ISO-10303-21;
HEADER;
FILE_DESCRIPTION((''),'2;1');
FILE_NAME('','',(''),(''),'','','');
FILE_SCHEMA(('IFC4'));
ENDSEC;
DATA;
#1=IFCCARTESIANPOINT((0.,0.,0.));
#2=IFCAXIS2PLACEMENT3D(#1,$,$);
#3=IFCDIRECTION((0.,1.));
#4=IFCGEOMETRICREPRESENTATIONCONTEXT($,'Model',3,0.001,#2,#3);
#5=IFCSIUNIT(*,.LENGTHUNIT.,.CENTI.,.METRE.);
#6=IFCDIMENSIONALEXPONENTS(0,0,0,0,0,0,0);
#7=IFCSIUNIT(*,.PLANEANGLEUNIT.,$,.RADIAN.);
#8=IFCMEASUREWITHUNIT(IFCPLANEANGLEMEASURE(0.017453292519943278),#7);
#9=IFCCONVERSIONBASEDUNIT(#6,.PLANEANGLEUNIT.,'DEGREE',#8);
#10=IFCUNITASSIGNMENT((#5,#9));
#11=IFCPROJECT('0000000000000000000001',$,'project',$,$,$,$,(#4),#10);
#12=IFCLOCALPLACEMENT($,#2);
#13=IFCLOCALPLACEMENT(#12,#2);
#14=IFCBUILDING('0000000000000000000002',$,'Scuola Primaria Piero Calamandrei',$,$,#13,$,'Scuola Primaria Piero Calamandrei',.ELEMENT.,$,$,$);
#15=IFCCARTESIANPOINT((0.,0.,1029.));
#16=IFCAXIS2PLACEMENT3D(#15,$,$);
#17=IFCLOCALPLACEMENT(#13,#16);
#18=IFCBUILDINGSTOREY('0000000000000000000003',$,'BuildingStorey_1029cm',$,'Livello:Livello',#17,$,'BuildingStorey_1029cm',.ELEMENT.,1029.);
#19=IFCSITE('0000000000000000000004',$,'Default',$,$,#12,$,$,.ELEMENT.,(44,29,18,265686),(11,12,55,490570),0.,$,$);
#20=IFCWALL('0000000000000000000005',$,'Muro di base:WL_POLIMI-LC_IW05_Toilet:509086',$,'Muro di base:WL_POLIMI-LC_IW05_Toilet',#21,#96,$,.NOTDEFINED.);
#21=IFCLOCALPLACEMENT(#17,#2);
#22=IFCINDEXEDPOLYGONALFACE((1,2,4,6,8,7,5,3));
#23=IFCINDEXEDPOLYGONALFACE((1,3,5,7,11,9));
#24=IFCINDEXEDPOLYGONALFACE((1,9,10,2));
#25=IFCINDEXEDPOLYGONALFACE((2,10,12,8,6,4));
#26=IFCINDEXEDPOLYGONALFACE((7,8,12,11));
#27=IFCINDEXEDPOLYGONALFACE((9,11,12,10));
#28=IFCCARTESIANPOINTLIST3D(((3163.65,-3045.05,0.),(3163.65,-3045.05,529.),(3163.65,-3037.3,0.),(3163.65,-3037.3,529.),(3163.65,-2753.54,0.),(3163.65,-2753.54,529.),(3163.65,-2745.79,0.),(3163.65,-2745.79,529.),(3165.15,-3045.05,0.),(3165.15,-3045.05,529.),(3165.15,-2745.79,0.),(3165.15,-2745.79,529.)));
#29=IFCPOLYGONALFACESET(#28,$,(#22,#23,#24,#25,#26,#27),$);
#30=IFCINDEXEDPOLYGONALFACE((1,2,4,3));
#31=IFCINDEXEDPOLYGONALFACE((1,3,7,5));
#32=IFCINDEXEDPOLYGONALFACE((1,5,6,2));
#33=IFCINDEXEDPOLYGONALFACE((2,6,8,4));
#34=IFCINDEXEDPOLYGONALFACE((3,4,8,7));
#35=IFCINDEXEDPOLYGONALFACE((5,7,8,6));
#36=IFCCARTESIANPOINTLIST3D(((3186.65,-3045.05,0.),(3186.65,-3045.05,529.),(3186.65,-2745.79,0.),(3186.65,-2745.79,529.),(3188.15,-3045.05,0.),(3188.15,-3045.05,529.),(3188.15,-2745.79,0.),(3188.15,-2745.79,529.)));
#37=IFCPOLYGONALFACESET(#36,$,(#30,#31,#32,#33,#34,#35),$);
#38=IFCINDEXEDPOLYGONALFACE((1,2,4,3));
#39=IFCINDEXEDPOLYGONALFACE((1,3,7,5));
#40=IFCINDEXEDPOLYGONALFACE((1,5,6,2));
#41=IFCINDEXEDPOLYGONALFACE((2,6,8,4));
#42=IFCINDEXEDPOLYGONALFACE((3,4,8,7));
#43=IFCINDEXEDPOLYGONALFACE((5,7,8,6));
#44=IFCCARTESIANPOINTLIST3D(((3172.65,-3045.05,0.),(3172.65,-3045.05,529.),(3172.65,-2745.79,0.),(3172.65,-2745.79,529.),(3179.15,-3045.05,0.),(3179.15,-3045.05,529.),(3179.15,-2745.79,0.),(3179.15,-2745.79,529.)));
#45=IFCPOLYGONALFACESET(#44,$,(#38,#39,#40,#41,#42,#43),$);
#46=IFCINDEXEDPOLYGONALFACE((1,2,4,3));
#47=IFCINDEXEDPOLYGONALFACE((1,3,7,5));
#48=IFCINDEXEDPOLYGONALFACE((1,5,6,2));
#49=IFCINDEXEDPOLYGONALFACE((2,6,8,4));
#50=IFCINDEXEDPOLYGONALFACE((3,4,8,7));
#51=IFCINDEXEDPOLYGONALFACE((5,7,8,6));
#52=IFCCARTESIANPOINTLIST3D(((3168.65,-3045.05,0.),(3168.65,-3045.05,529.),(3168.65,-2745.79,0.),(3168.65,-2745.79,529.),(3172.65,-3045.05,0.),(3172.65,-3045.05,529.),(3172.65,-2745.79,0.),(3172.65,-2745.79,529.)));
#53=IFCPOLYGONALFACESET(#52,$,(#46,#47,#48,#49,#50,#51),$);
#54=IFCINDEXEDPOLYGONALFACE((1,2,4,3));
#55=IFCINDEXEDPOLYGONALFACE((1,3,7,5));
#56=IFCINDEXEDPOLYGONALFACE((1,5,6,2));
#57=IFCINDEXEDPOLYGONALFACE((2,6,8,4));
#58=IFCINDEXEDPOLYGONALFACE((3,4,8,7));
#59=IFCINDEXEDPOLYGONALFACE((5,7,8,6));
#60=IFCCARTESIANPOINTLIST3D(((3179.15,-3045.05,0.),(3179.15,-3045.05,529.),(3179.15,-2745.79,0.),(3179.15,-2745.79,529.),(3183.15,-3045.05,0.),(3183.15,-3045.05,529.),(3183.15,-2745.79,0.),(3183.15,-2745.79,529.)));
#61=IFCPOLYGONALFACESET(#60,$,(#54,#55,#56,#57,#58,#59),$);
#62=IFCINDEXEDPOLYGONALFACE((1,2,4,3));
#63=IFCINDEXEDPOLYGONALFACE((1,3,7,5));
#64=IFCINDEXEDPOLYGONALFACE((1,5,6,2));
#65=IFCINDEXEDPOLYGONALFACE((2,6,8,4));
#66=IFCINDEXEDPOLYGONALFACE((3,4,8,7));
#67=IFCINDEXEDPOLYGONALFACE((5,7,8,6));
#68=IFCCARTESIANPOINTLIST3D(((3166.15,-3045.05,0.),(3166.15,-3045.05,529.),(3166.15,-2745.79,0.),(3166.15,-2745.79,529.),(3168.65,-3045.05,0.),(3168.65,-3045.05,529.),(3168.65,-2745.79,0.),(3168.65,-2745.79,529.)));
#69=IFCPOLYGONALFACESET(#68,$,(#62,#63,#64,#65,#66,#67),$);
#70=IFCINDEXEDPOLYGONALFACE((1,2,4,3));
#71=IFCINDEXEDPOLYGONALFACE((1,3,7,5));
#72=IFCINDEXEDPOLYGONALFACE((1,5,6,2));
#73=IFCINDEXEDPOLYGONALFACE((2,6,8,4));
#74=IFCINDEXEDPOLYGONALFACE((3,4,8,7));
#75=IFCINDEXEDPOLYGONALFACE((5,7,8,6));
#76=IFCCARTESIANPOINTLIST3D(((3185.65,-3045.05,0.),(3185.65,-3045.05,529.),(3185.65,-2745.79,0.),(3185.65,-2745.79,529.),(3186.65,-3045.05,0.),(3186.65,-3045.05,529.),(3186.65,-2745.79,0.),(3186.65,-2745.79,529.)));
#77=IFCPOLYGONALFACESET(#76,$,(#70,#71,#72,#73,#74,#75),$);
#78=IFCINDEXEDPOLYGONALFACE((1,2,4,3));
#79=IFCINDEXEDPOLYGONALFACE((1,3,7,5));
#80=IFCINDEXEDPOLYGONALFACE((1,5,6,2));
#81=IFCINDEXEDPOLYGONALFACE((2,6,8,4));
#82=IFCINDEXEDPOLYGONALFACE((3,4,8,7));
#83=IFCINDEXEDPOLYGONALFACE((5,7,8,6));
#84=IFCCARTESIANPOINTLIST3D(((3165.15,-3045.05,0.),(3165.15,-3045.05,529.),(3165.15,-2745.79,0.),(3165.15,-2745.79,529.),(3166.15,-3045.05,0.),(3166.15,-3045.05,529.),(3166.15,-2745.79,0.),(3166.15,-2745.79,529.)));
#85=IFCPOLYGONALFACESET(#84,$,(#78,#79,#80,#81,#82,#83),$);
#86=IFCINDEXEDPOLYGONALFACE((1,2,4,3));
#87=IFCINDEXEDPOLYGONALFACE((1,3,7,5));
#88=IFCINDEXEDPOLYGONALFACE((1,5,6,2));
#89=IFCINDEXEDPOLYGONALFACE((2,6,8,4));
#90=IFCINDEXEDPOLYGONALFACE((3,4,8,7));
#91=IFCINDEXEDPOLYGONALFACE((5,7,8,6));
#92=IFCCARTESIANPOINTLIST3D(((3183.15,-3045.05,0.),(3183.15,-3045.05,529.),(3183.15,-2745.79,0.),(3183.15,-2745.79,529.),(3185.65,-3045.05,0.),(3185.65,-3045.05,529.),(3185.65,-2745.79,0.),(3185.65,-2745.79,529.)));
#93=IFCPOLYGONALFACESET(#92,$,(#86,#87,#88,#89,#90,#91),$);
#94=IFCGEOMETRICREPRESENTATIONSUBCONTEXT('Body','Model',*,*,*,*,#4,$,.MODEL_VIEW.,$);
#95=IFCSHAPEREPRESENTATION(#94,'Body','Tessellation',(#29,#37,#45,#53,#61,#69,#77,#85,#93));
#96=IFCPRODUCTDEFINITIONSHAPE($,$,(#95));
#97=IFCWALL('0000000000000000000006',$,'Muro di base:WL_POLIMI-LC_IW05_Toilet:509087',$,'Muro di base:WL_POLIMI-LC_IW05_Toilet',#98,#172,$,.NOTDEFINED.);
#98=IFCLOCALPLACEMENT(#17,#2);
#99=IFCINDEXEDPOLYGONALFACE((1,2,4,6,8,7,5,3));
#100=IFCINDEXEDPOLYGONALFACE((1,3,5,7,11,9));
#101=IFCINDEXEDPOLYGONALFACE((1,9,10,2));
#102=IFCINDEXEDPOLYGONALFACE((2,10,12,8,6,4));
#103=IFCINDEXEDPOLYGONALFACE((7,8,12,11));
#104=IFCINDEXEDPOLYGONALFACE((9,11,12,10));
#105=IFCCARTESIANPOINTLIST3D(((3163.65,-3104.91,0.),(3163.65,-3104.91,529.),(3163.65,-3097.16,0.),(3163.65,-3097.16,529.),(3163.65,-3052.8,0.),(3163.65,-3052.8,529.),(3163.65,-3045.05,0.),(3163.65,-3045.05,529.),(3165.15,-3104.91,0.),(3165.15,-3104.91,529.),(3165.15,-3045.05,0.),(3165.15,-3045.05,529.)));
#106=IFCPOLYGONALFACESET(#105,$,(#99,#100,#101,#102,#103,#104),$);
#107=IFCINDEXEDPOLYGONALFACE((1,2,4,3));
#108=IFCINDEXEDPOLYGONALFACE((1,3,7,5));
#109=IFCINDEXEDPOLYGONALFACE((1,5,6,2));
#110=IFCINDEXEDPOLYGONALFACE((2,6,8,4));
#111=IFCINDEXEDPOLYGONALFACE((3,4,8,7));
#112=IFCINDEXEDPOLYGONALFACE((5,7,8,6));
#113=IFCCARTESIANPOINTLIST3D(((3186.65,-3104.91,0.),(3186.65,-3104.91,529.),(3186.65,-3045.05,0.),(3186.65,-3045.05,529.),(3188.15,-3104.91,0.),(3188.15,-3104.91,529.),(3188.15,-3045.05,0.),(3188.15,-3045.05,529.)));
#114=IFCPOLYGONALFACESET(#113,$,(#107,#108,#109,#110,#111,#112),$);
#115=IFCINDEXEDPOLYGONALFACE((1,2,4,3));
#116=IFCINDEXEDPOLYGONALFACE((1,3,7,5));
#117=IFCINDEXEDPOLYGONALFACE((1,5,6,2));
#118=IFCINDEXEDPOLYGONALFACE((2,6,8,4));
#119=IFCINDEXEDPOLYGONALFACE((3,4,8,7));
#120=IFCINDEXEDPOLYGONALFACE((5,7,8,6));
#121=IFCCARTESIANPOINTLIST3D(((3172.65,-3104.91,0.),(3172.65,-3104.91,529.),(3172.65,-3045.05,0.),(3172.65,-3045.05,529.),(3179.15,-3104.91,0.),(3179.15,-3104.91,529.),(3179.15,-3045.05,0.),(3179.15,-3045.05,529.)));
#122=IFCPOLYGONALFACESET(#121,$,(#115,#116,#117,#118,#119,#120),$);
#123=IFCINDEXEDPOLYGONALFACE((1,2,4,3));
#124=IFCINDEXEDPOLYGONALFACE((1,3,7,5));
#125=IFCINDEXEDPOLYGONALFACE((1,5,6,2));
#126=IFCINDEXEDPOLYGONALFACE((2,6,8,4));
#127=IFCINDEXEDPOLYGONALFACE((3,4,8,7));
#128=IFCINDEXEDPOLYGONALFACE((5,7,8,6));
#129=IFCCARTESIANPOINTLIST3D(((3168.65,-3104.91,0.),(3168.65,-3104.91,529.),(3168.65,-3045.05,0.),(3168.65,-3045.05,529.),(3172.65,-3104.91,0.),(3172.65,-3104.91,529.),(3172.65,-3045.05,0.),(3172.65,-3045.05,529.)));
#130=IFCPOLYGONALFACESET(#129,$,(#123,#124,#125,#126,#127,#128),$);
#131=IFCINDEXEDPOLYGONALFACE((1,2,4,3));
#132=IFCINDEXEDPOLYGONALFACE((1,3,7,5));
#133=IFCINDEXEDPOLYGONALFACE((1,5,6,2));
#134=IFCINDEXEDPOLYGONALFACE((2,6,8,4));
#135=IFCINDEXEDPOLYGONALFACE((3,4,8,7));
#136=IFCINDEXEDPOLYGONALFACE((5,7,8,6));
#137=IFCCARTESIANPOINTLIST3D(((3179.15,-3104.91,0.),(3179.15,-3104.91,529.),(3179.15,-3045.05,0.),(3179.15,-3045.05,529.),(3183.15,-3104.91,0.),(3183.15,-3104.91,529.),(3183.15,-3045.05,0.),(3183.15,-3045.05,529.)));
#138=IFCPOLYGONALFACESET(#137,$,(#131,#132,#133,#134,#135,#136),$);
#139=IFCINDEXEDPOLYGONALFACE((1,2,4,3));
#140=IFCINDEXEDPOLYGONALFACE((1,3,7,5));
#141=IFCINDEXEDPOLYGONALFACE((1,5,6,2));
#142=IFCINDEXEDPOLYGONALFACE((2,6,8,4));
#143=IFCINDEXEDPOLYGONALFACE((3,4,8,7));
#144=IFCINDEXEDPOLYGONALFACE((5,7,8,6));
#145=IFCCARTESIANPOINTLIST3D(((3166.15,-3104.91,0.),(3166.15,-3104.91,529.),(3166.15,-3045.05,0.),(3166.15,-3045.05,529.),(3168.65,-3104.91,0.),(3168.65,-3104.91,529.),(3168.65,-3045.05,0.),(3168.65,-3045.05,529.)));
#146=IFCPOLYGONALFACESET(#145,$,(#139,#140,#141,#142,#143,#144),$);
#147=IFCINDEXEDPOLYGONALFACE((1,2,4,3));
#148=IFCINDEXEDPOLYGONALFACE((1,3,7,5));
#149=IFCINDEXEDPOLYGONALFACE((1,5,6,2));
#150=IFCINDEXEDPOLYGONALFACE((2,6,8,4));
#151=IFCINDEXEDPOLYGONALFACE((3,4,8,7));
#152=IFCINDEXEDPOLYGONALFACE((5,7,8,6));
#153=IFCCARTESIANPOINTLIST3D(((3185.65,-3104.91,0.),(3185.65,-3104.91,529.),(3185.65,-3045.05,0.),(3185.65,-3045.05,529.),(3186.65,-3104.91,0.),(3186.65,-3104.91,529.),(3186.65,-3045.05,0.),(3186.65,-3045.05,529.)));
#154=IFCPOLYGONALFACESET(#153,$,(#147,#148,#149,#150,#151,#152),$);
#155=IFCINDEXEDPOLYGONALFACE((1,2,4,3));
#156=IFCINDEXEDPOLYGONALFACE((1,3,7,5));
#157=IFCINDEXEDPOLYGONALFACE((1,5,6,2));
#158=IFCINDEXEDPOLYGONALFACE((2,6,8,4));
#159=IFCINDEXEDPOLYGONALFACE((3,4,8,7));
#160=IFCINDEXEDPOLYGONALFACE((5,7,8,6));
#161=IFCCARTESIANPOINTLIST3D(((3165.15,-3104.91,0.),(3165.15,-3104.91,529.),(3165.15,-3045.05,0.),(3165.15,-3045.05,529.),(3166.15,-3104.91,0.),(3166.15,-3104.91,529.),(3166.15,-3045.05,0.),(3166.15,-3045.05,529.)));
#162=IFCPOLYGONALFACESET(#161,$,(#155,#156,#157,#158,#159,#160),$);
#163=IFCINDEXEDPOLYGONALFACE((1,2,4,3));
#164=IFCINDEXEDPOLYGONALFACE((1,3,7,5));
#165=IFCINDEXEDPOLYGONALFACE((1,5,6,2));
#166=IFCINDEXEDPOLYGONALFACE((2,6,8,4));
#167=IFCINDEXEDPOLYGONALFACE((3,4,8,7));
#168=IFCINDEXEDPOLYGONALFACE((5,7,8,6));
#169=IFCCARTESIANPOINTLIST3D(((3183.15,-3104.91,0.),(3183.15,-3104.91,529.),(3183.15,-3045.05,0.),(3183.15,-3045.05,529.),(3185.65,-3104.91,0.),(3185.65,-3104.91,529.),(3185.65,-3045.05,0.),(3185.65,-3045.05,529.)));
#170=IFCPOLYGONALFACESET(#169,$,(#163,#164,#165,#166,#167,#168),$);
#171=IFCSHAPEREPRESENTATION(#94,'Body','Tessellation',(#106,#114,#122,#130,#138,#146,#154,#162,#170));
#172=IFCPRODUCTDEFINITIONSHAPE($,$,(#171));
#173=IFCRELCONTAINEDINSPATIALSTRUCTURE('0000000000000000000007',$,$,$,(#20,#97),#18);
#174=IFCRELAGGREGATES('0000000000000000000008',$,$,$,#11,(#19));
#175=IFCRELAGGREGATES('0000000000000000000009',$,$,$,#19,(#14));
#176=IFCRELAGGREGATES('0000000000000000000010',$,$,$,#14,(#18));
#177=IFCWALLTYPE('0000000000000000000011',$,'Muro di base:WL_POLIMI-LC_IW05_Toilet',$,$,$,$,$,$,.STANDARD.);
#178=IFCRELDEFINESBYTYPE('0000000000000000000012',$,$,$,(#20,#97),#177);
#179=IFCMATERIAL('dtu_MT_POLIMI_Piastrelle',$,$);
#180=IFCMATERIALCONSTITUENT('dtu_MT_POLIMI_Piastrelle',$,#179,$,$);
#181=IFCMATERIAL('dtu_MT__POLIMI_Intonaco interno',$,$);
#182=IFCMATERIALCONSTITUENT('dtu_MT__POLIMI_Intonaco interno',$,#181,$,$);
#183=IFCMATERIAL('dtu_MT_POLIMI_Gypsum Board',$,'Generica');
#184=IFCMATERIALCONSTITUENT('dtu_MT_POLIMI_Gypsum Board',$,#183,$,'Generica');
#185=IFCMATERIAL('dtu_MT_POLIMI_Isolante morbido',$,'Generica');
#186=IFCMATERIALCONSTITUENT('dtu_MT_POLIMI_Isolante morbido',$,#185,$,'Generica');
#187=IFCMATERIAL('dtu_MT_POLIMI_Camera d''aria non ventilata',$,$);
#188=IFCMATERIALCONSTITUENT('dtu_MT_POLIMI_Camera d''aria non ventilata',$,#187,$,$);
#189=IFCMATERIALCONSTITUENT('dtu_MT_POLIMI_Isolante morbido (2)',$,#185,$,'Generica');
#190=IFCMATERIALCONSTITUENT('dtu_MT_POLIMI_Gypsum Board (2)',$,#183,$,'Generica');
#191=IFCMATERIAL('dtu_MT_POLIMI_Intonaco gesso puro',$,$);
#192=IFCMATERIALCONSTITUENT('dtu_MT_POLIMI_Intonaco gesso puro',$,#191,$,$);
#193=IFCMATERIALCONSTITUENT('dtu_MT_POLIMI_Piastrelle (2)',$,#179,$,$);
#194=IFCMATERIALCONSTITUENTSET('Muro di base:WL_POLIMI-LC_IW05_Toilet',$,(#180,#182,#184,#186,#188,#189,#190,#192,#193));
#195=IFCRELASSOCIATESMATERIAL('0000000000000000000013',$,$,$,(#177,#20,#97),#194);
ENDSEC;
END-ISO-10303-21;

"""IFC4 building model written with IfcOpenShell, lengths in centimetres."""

from ifc_helpers import new_model, entity, si_unit, converted_unit, direction, frame, origin, place, context, subcontext, project, spatial, indexed_curve, outline, extrude, material, constituent, constituent_set, type_object, element, save


model = new_model("IFC4")

# Units and contexts
model_context = context("Model", 3, precision=0.001, world=origin(), true_north=direction((0.0, 1.0)))
body_context = subcontext(model_context, "Body", "Model", "MODEL_VIEW")
ifc_project = project(units=[si_unit("LENGTHUNIT", "METRE", prefix="CENTI"), converted_unit("PLANEANGLEUNIT", "DEGREE", entity("IfcPlaneAngleMeasure", 0.017453292519943278), si_unit("PLANEANGLEUNIT", "RADIAN"), dimensions=[0, 0, 0, 0, 0, 0, 0])], contexts=[model_context])

# Site, building, storey
site_placement = place(None, origin())
site = spatial("IfcSite", under=ifc_project, at=site_placement, Name="Default", CompositionType="ELEMENT", RefLatitude=(44, 29, 18, 265686), RefLongitude=(11, 12, 55, 490570), RefElevation=0.0)
building_placement = place(site_placement, origin())
building = spatial("IfcBuilding", under=site, at=building_placement, Name="Scuola Primaria Piero Calamandrei", LongName="Scuola Primaria Piero Calamandrei", CompositionType="ELEMENT")
storey_placement = place(building_placement, frame((0.0, 0.0, 1029.0)))
storey = spatial("IfcBuildingStorey", under=building, at=storey_placement, Name="BuildingStorey_1029cm", ObjectType="Livello:Livello", LongName="BuildingStorey_1029cm", CompositionType="ELEMENT", Elevation=1029.0)

# Shared definitions
ifc_material_1 = material(Name="dtu_MT_POLIMI_Isolante morbido", Category="Generica")
ifc_material_2 = material(Name="dtu_MT_POLIMI_Gypsum Board", Category="Generica")
ifc_material_3 = material(Name="dtu_MT__POLIMI_Intonaco interno")

# Shared definitions
ifc_material_4 = material(Name="dtu_MT_POLIMI_Camera d'aria non ventilata")
ifc_material_5 = material(Name="dtu_MT_POLIMI_Intonaco gesso puro")

# Shared definitions
ifc_material_6 = material(Name="dtu_MT_POLIMI_Piastrelle")

# Walls
ifc_constituent_1 = constituent(ifc_material_6, Name="dtu_MT_POLIMI_Piastrelle")
ifc_constituent_2 = constituent(ifc_material_3, Name="dtu_MT__POLIMI_Intonaco interno")
ifc_constituent_3 = constituent(ifc_material_2, Name="dtu_MT_POLIMI_Gypsum Board", Category="Generica")
ifc_constituent_4 = constituent(ifc_material_1, Name="dtu_MT_POLIMI_Isolante morbido", Category="Generica")
ifc_constituent_5 = constituent(ifc_material_4, Name="dtu_MT_POLIMI_Camera d'aria non ventilata")
ifc_constituent_6 = constituent(ifc_material_1, Name="dtu_MT_POLIMI_Isolante morbido (2)", Category="Generica")
ifc_constituent_7 = constituent(ifc_material_2, Name="dtu_MT_POLIMI_Gypsum Board (2)", Category="Generica")
ifc_constituent_8 = constituent(ifc_material_5, Name="dtu_MT_POLIMI_Intonaco gesso puro")
ifc_constituent_9 = constituent(ifc_material_6, Name="dtu_MT_POLIMI_Piastrelle (2)")
ifc_constituent_set_1 = constituent_set(constituents=[ifc_constituent_1, ifc_constituent_2, ifc_constituent_3, ifc_constituent_4, ifc_constituent_5, ifc_constituent_6, ifc_constituent_7, ifc_constituent_8, ifc_constituent_9], Name="Muro di base:WL_POLIMI-LC_IW05_Toilet")
wall_type_1 = type_object("IfcWallType", Name="Muro di base:WL_POLIMI-LC_IW05_Toilet", PredefinedType="STANDARD", material=ifc_constituent_set_1)
wall_1_placement = place(storey_placement, frame((3175.9, -3045.05, 0.0), z_axis=(0.0, 0.0, 1.0), x_axis=(0.0, 1.0, 0.0)))
element("IfcWall", 1, at=wall_1_placement, inside=storey, type_object=wall_type_1, material=ifc_constituent_set_1, Name="Muro di base:WL_POLIMI-LC_IW05_Toilet:509086", ObjectType="Muro di base:WL_POLIMI-LC_IW05_Toilet", PredefinedType="NOTDEFINED", context=body_context, shape_type="SweptSolid", body=[
    extrude(outline(indexed_curve([(-141.88, -0.5), (141.88, -0.5), (149.63, -0.5), (149.63, 1.0), (-149.63, 1.0), (-149.63, -0.5), (-141.88, -0.5)], self_intersect=False)), frame((149.63, 11.75, 0.0), z_axis=(0.0, 0.0, 1.0), x_axis=(-1.0, 0.0, 0.0)), (0.0, 0.0, 1.0), 529.0),
    extrude(outline(indexed_curve([(-0.75, -149.63), (0.75, -149.63), (0.75, 149.63), (-0.75, 149.63), (-0.75, -149.63)], self_intersect=False)), frame((149.63, -11.5, 0.0), z_axis=(0.0, 0.0, 1.0), x_axis=(0.0, 1.0, 0.0)), (0.0, 0.0, 1.0), 529.0),
    extrude(outline(indexed_curve([(-149.63, -3.25), (149.63, -3.25), (149.63, 3.25), (-149.63, 3.25), (-149.63, -3.25)], self_intersect=False)), frame((149.63, 0.0, 0.0)), (0.0, 0.0, 1.0), 529.0),
    extrude(outline(indexed_curve([(-149.63, -2.0), (149.63, -2.0), (149.63, 2.0), (-149.63, 2.0), (-149.63, -2.0)], self_intersect=False)), frame((149.63, 5.25, 0.0)), (0.0, 0.0, 1.0), 529.0),
    extrude(outline(indexed_curve([(-149.63, -2.0), (149.63, -2.0), (149.63, 2.0), (-149.63, 2.0), (-149.63, -2.0)], self_intersect=False)), frame((149.63, -5.25, 0.0)), (0.0, 0.0, 1.0), 529.0),
    extrude(outline(indexed_curve([(-149.63, -1.25), (149.63, -1.25), (149.63, 1.25), (-149.63, 1.25), (-149.63, -1.25)], self_intersect=False)), frame((149.63, 8.5, 0.0)), (0.0, 0.0, 1.0), 529.0),
    extrude(outline(indexed_curve([(-149.63, -0.5), (149.63, -0.5), (149.63, 0.5), (-149.63, 0.5), (-149.63, -0.5)], self_intersect=False)), frame((149.63, -10.25, 0.0)), (0.0, 0.0, 1.0), 529.0),
    extrude(outline(indexed_curve([(-149.63, -0.5), (149.63, -0.5), (149.63, 0.5), (-149.63, 0.5), (-149.63, -0.5)], self_intersect=False)), frame((149.63, 10.25, 0.0)), (0.0, 0.0, 1.0), 529.0),
    extrude(outline(indexed_curve([(-149.63, -1.25), (149.63, -1.25), (149.63, 1.25), (-149.63, 1.25), (-149.63, -1.25)], self_intersect=False)), frame((149.63, -8.5, 0.0)), (0.0, 0.0, 1.0), 529.0),
])
wall_2_placement = place(storey_placement, frame((3175.9, -3104.91, 0.0), z_axis=(0.0, 0.0, 1.0), x_axis=(0.0, 1.0, 0.0)))
element("IfcWall", 2, at=wall_2_placement, inside=storey, type_object=wall_type_1, material=ifc_constituent_set_1, Name="Muro di base:WL_POLIMI-LC_IW05_Toilet:509087", ObjectType="Muro di base:WL_POLIMI-LC_IW05_Toilet", PredefinedType="NOTDEFINED", context=body_context, shape_type="SweptSolid", body=[
    extrude(outline(indexed_curve([(-22.18, -0.5), (22.18, -0.5), (29.93, -0.5), (29.93, 1.0), (-29.93, 1.0), (-29.93, -0.5), (-22.18, -0.5)], self_intersect=False)), frame((29.93, 11.75, 0.0), z_axis=(0.0, 0.0, 1.0), x_axis=(-1.0, 0.0, 0.0)), (0.0, 0.0, 1.0), 529.0),
    extrude(outline(indexed_curve([(-0.75, -29.93), (0.75, -29.93), (0.75, 29.93), (-0.75, 29.93), (-0.75, -29.93)], self_intersect=False)), frame((29.93, -11.5, 0.0), z_axis=(0.0, 0.0, 1.0), x_axis=(0.0, 1.0, 0.0)), (0.0, 0.0, 1.0), 529.0),
    extrude(outline(indexed_curve([(-29.93, -3.25), (29.93, -3.25), (29.93, 3.25), (-29.93, 3.25), (-29.93, -3.25)], self_intersect=False)), frame((29.93, 0.0, 0.0)), (0.0, 0.0, 1.0), 529.0),
    extrude(outline(indexed_curve([(-29.93, -2.0), (29.93, -2.0), (29.93, 2.0), (-29.93, 2.0), (-29.93, -2.0)], self_intersect=False)), frame((29.93, 5.25, 0.0)), (0.0, 0.0, 1.0), 529.0),
    extrude(outline(indexed_curve([(-29.93, -2.0), (29.93, -2.0), (29.93, 2.0), (-29.93, 2.0), (-29.93, -2.0)], self_intersect=False)), frame((29.93, -5.25, 0.0)), (0.0, 0.0, 1.0), 529.0),
    extrude(outline(indexed_curve([(-29.93, -1.25), (29.93, -1.25), (29.93, 1.25), (-29.93, 1.25), (-29.93, -1.25)], self_intersect=False)), frame((29.93, 8.5, 0.0)), (0.0, 0.0, 1.0), 529.0),
    extrude(outline(indexed_curve([(-29.93, -0.5), (29.93, -0.5), (29.93, 0.5), (-29.93, 0.5), (-29.93, -0.5)], self_intersect=False)), frame((29.93, -10.25, 0.0)), (0.0, 0.0, 1.0), 529.0),
    extrude(outline(indexed_curve([(-29.93, -0.5), (29.93, -0.5), (29.93, 0.5), (-29.93, 0.5), (-29.93, -0.5)], self_intersect=False)), frame((29.93, 10.25, 0.0)), (0.0, 0.0, 1.0), 529.0),
    extrude(outline(indexed_curve([(-29.93, -1.25), (29.93, -1.25), (29.93, 1.25), (-29.93, 1.25), (-29.93, -1.25)], self_intersect=False)), frame((29.93, -8.5, 0.0)), (0.0, 0.0, 1.0), 529.0),
])

save(model, "model.ifc")
